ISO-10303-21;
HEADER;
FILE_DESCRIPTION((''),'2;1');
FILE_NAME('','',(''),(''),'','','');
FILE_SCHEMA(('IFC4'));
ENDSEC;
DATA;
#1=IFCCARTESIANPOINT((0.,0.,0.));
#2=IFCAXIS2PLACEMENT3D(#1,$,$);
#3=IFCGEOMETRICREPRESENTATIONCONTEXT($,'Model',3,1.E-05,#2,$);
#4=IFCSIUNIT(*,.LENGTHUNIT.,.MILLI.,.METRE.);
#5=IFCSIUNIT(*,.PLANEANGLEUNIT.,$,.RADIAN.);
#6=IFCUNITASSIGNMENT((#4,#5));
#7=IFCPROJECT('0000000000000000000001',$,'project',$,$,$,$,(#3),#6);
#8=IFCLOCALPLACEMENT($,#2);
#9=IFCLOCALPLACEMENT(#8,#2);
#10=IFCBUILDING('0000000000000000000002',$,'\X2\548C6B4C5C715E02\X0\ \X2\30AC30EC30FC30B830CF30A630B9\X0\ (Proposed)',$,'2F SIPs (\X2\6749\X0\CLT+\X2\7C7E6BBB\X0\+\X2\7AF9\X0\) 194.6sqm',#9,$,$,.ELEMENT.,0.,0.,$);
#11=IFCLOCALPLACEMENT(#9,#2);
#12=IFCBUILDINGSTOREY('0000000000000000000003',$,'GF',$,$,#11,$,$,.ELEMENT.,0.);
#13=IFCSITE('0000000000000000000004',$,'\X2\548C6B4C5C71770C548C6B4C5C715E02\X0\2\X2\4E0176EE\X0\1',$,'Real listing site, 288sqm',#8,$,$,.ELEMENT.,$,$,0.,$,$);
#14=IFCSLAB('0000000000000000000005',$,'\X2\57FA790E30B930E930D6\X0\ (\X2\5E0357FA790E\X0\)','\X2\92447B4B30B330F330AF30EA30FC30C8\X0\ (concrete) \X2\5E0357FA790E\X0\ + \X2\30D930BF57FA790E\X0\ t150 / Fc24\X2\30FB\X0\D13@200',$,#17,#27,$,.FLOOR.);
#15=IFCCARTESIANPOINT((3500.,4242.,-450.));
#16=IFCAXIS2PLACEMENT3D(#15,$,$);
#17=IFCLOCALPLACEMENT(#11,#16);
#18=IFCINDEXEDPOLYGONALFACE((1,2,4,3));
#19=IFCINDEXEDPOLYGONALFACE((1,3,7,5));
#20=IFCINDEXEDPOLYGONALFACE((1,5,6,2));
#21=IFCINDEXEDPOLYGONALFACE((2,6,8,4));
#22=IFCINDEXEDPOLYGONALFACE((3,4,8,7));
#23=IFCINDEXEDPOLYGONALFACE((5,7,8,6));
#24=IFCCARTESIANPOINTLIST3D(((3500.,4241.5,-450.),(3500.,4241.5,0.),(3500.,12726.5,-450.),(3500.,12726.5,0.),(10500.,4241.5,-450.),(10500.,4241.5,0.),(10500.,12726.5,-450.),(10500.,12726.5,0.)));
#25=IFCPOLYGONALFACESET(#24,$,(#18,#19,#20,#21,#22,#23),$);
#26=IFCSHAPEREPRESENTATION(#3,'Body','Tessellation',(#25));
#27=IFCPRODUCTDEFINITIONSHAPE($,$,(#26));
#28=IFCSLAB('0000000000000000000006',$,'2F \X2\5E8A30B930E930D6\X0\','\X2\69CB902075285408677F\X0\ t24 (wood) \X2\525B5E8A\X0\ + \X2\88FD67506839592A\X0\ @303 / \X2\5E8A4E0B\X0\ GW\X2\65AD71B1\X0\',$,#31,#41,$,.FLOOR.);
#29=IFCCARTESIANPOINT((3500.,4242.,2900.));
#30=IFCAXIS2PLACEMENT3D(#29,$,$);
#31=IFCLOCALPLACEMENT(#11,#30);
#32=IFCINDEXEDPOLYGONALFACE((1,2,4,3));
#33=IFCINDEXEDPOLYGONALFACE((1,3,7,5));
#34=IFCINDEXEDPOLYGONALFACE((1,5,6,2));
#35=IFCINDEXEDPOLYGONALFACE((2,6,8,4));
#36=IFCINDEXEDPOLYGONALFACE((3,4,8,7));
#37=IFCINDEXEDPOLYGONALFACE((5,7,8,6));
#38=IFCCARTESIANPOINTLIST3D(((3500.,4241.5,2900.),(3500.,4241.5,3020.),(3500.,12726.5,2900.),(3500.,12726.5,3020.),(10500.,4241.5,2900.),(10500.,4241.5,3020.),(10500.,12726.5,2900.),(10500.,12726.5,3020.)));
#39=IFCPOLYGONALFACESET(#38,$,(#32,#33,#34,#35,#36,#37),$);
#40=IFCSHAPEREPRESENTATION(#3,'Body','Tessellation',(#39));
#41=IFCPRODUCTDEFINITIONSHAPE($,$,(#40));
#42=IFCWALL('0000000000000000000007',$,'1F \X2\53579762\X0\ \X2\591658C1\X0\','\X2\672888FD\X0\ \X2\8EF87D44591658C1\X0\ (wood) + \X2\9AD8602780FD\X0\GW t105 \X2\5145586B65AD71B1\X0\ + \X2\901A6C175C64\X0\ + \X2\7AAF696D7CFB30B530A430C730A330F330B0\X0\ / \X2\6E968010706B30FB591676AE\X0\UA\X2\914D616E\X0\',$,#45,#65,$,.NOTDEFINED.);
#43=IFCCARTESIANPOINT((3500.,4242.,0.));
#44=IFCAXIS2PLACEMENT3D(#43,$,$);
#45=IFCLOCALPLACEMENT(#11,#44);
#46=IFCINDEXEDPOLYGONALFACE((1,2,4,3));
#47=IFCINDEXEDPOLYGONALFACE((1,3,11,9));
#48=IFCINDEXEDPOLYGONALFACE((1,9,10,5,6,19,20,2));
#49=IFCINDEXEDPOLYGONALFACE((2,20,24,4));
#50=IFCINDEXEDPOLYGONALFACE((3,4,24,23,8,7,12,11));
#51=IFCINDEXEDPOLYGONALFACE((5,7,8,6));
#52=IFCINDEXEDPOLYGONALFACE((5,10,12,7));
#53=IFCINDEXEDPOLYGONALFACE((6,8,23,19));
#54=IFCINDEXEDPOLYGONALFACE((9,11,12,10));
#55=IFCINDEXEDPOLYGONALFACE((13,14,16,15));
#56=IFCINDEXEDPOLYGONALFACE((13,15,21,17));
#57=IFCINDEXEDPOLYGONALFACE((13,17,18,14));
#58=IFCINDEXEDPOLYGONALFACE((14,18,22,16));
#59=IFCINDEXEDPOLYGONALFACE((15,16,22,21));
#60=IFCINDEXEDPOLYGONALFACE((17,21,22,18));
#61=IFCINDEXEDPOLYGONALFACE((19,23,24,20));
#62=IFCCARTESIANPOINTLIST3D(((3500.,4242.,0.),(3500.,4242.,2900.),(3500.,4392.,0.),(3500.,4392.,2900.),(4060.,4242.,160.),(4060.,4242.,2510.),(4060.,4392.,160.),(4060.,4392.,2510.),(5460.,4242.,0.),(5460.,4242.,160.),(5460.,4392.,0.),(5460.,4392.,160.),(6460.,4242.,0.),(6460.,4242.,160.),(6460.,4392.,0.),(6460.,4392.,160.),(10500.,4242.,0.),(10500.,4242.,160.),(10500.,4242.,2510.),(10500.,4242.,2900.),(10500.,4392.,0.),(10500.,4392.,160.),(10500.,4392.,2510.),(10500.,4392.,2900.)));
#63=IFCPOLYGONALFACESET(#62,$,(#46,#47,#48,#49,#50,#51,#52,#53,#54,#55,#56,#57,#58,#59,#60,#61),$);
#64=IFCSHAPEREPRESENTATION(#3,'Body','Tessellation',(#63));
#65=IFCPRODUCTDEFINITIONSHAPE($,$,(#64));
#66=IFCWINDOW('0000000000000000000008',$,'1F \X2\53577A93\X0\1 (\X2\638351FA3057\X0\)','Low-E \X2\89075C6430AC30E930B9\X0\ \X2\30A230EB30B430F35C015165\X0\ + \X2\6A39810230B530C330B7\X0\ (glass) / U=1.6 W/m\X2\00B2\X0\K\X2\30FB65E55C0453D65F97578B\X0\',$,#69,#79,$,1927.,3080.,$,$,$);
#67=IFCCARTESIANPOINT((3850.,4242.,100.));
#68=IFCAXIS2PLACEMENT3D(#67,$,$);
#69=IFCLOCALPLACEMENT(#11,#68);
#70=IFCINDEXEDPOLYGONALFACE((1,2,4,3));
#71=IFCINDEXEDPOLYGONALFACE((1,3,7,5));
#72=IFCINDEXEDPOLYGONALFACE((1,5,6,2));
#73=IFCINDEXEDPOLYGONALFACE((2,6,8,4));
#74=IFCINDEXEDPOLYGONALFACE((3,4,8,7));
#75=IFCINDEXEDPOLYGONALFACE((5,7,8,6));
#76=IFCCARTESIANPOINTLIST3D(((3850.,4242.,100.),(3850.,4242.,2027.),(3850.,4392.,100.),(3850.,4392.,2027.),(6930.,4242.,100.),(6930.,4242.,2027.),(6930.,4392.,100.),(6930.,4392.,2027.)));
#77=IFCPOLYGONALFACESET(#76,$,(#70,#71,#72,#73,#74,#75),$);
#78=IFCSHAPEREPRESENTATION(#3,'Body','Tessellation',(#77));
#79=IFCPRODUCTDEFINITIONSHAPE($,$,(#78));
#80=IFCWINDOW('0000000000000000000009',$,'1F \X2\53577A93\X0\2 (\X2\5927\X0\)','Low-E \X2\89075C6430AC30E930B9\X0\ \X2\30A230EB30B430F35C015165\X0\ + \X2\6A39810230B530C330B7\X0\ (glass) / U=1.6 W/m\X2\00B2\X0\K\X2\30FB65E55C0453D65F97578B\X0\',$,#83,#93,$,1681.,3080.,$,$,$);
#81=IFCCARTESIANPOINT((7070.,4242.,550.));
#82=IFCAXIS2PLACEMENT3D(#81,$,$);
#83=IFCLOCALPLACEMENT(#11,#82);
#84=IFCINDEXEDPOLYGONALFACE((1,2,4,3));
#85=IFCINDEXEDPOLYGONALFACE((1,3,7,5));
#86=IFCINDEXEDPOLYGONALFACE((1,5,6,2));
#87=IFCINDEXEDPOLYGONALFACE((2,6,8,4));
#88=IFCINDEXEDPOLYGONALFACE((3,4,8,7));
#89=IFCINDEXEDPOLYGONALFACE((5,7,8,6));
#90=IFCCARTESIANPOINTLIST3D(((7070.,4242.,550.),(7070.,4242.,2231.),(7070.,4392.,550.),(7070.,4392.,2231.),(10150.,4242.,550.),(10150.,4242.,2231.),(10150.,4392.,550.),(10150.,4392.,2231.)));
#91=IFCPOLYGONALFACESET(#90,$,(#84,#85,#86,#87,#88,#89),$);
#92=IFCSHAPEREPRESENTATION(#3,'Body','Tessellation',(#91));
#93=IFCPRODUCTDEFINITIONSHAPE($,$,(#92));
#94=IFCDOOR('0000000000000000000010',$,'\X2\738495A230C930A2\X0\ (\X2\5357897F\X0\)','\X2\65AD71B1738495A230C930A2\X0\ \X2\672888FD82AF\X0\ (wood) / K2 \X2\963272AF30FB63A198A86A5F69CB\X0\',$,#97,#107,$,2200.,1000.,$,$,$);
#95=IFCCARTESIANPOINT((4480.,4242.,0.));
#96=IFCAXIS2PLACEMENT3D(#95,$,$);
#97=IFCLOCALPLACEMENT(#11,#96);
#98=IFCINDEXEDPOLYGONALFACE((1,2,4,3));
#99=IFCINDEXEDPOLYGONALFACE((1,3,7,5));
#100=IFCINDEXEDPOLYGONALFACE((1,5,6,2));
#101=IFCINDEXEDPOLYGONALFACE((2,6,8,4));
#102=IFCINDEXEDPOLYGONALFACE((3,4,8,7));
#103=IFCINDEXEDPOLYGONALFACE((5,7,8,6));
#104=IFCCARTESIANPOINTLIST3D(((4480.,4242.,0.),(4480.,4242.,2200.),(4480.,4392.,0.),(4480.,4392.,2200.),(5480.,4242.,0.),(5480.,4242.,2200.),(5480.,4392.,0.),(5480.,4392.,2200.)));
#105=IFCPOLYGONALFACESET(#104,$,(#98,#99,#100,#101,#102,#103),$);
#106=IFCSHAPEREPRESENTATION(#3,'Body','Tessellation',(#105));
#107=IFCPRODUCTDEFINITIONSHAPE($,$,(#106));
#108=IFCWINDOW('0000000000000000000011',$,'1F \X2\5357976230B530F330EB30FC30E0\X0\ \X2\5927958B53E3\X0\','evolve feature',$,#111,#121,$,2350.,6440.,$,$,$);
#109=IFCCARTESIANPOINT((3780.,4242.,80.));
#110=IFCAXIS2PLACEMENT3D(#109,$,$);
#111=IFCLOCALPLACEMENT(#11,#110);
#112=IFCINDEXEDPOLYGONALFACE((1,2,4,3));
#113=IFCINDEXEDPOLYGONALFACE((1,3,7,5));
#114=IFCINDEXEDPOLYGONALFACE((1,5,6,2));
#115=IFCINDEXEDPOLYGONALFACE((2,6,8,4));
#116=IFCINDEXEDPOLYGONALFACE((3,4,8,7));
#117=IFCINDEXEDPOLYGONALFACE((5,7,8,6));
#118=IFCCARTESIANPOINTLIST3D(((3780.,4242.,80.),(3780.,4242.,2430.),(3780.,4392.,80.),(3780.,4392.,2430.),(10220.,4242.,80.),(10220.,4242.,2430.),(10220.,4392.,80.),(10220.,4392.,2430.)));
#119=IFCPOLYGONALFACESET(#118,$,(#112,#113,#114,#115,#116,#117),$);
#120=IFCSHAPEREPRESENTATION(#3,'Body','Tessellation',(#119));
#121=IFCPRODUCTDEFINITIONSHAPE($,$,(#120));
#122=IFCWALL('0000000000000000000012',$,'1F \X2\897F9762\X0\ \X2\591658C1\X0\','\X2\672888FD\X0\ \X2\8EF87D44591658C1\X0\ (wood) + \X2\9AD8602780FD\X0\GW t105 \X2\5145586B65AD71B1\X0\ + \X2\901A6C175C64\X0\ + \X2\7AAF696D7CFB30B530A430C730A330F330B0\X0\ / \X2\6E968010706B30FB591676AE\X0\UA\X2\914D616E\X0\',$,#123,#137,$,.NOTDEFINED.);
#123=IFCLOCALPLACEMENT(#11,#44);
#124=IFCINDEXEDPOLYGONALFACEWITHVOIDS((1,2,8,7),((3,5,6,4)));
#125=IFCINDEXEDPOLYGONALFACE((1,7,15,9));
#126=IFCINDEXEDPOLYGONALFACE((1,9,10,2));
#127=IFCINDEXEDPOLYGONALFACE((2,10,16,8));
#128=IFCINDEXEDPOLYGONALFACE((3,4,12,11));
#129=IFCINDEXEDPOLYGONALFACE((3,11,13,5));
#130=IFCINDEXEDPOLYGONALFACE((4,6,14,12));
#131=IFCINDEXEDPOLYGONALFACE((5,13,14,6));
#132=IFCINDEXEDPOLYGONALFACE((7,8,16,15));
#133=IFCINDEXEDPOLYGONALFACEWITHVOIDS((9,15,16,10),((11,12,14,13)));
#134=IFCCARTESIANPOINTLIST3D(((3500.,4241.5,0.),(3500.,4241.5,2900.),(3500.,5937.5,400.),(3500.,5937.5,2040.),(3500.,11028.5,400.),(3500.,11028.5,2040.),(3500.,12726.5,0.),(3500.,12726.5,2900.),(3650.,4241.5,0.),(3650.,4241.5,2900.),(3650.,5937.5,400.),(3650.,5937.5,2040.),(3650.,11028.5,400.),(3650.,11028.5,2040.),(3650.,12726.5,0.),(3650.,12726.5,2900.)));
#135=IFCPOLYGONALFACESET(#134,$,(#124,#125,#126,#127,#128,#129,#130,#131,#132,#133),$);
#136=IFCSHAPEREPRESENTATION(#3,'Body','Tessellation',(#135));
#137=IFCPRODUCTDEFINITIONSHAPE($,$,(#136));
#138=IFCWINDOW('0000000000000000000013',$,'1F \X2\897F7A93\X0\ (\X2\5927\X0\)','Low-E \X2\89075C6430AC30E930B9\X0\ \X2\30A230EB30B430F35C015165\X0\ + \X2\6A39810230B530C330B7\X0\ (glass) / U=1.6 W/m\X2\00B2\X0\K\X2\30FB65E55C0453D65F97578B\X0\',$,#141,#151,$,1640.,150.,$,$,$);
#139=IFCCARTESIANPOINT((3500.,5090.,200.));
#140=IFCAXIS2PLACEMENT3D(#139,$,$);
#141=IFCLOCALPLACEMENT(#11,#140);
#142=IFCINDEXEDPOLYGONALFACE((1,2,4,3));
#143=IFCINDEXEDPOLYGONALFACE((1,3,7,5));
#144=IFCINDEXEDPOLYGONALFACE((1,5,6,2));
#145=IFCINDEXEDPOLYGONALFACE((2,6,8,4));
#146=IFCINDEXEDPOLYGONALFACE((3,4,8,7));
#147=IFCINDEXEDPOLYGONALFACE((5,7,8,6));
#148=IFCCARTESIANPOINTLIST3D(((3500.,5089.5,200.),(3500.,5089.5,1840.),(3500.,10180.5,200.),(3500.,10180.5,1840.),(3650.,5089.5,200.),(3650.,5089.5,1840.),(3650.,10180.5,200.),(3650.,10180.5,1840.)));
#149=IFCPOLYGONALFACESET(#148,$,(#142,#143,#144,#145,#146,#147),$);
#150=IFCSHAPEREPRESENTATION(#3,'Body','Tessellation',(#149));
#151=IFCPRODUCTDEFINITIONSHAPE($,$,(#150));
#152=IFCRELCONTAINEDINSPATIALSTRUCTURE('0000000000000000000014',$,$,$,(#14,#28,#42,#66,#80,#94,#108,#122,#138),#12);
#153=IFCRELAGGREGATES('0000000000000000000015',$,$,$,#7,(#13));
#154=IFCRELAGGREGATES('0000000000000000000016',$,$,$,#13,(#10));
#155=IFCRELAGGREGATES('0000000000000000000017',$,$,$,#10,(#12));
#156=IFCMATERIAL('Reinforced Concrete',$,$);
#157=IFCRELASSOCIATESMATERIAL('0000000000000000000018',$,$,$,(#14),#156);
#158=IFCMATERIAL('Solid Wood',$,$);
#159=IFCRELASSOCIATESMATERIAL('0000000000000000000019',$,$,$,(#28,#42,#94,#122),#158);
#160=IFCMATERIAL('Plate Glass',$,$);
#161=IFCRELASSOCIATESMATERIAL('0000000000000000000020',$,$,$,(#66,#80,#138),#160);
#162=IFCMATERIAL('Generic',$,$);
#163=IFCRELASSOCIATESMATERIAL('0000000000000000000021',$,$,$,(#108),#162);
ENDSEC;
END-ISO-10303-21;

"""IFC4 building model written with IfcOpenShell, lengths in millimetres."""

from ifc_helpers import new_model, si_unit, frame, frame_2d, origin, place, context, project, spatial, rectangle, extrude, material, element, fill, save


model = new_model("IFC4")

# Units and contexts
model_context = context("Model", 3, precision=1e-05, world=origin())
ifc_project = project(units=[si_unit("LENGTHUNIT", "METRE", prefix="MILLI"), si_unit("PLANEANGLEUNIT", "RADIAN")], contexts=[model_context])

# Site, building, storey
site_placement = place(None, origin())
site = spatial("IfcSite", under=ifc_project, at=site_placement, Name="和歌山県和歌山市2丁目1", ObjectType="Real listing site, 288sqm", CompositionType="ELEMENT", RefElevation=0.0)
building_placement = place(site_placement, origin())
building = spatial("IfcBuilding", under=site, at=building_placement, Name="和歌山市 ガレージハウス (Proposed)", ObjectType="2F SIPs (杉CLT+籾殻+竹) 194.6sqm", CompositionType="ELEMENT", ElevationOfRefHeight=0.0, ElevationOfTerrain=0.0)
storey_placement = place(building_placement, origin())
storey = spatial("IfcBuildingStorey", under=building, at=storey_placement, Name="GF", CompositionType="ELEMENT", Elevation=0.0)

# Slabs
ifc_material_1 = material(Name="Reinforced Concrete")
slab_1_placement = place(storey_placement, frame((3500.0, 4242.0, -450.0)))
element("IfcSlab", 1, at=slab_1_placement, inside=storey, material=ifc_material_1, Name="基礎スラブ (布基礎)", Description="鉄筋コンクリート (concrete) 布基礎 + ベタ基礎 t150 / Fc24・D13@200", PredefinedType="FLOOR", context=model_context, shape_type="SweptSolid", body=[
    extrude(rectangle(XDim=7000.0, YDim=8485.0, at=frame_2d((3500.0, 4242.0))), frame((3500.0, 4242.0, -450.0)), (0.0, 0.0, 1.0), 450.0),
])
ifc_material_2 = material(Name="Solid Wood")
slab_2_placement = place(storey_placement, frame((3500.0, 4242.0, 2900.0)))
element("IfcSlab", 2, at=slab_2_placement, inside=storey, material=ifc_material_2, Name="2F 床スラブ", Description="構造用合板 t24 (wood) 剛床 + 製材根太 @303 / 床下 GW断熱", PredefinedType="FLOOR", context=model_context, shape_type="SweptSolid", body=[
    extrude(rectangle(XDim=7000.0, YDim=8485.0, at=frame_2d((3500.0, 4242.0))), frame((3500.0, 4242.0, 2900.0)), (0.0, 0.0, 1.0), 120.0),
])

# Wall, openings, windows, door
wall_1_placement = place(storey_placement, frame((3500.0, 4242.0, 0.0)))
wall_1 = element("IfcWall", 3, at=wall_1_placement, inside=storey, material=ifc_material_2, Name="1F 南面 外壁", Description="木製 軸組外壁 (wood) + 高性能GW t105 充填断熱 + 通気層 + 窯業系サイディング / 準耐火・外皮UA配慮", PredefinedType="NOTDEFINED", context=model_context, shape_type="SweptSolid", body=[
    extrude(rectangle(XDim=7000.0, YDim=150.0, at=frame_2d((3500.0, 75.0))), frame((3500.0, 4242.0, 0.0)), (0.0, 0.0, 1.0), 2900.0),
])
opening_1_placement = place(storey_placement, frame((3850.0, 4242.0, 100.0)))
opening_1 = element("IfcOpeningElement", 4, at=opening_1_placement, cuts=wall_1, PredefinedType="NOTDEFINED", context=model_context, shape_type="SweptSolid", body=[
    extrude(rectangle(XDim=3080.0, YDim=150.0, at=frame_2d((1540.0, 75.0))), frame((3850.0, 4242.0, 100.0)), (0.0, 0.0, 1.0), 1927.0),
])
opening_2_placement = place(storey_placement, frame((7070.0, 4242.0, 550.0)))
opening_2 = element("IfcOpeningElement", 5, at=opening_2_placement, cuts=wall_1, PredefinedType="NOTDEFINED", context=model_context, shape_type="SweptSolid", body=[
    extrude(rectangle(XDim=3080.0, YDim=150.0, at=frame_2d((1540.0, 75.0))), frame((7070.0, 4242.0, 550.0)), (0.0, 0.0, 1.0), 1681.0),
])
opening_3_placement = place(storey_placement, frame((4480.0, 4242.0, 0.0)))
opening_3 = element("IfcOpeningElement", 6, at=opening_3_placement, cuts=wall_1, PredefinedType="NOTDEFINED", context=model_context, shape_type="SweptSolid", body=[
    extrude(rectangle(XDim=1000.0, YDim=150.0, at=frame_2d((500.0, 75.0))), frame((4480.0, 4242.0, 0.0)), (0.0, 0.0, 1.0), 2200.0),
])
opening_4_placement = place(storey_placement, frame((3780.0, 4242.0, 80.0)))
opening_4 = element("IfcOpeningElement", 7, at=opening_4_placement, cuts=wall_1, PredefinedType="NOTDEFINED", context=model_context, shape_type="SweptSolid", body=[
    extrude(rectangle(XDim=6440.0, YDim=150.0, at=frame_2d((3220.0, 75.0))), frame((3780.0, 4242.0, 80.0)), (0.0, 0.0, 1.0), 2350.0),
])
ifc_material_3 = material(Name="Plate Glass")
window_1_placement = place(storey_placement, frame((3850.0, 4242.0, 100.0)))
window_1 = element("IfcWindow", 8, at=window_1_placement, inside=storey, material=ifc_material_3, Name="1F 南窓1 (掃出し)", Description="Low-E 複層ガラス アルゴン封入 + 樹脂サッシ (glass) / U=1.6 W/m²K・日射取得型", OverallHeight=1927.0, OverallWidth=3080.0, context=model_context, shape_type="SweptSolid", body=[
    extrude(rectangle(XDim=3080.0, YDim=150.0, at=frame_2d((1540.0, 75.0))), frame((3850.0, 4242.0, 100.0)), (0.0, 0.0, 1.0), 1927.0),
])
fill(opening_1, window_1)
window_2_placement = place(storey_placement, frame((7070.0, 4242.0, 550.0)))
window_2 = element("IfcWindow", 9, at=window_2_placement, inside=storey, material=ifc_material_3, Name="1F 南窓2 (大)", Description="Low-E 複層ガラス アルゴン封入 + 樹脂サッシ (glass) / U=1.6 W/m²K・日射取得型", OverallHeight=1681.0, OverallWidth=3080.0, context=model_context, shape_type="SweptSolid", body=[
    extrude(rectangle(XDim=3080.0, YDim=150.0, at=frame_2d((1540.0, 75.0))), frame((7070.0, 4242.0, 550.0)), (0.0, 0.0, 1.0), 1681.0),
])
fill(opening_2, window_2)
door_placement = place(storey_placement, frame((4480.0, 4242.0, 0.0)))
door = element("IfcDoor", 10, at=door_placement, inside=storey, material=ifc_material_2, Name="玄関ドア (南西)", Description="断熱玄関ドア 木製芯 (wood) / K2 防犯・採風機構", OverallHeight=2200.0, OverallWidth=1000.0, context=model_context, shape_type="SweptSolid", body=[
    extrude(rectangle(XDim=1000.0, YDim=150.0, at=frame_2d((500.0, 75.0))), frame((4480.0, 4242.0, 0.0)), (0.0, 0.0, 1.0), 2200.0),
])
fill(opening_3, door)
ifc_material_4 = material(Name="Generic")
window_3_placement = place(storey_placement, frame((3780.0, 4242.0, 80.0)))
window_3 = element("IfcWindow", 11, at=window_3_placement, inside=storey, material=ifc_material_4, Name="1F 南面サンルーム 大開口", Description="evolve feature", OverallHeight=2350.0, OverallWidth=6440.0, context=model_context, shape_type="SweptSolid", body=[
    extrude(rectangle(XDim=6440.0, YDim=150.0, at=frame_2d((3220.0, 75.0))), frame((3780.0, 4242.0, 80.0)), (0.0, 0.0, 1.0), 2350.0),
])
fill(opening_4, window_3)

# Wall, opening, window
wall_2_placement = place(storey_placement, frame((3500.0, 4242.0, 0.0)))
wall_2 = element("IfcWall", 12, at=wall_2_placement, inside=storey, material=ifc_material_2, Name="1F 西面 外壁", Description="木製 軸組外壁 (wood) + 高性能GW t105 充填断熱 + 通気層 + 窯業系サイディング / 準耐火・外皮UA配慮", PredefinedType="NOTDEFINED", context=model_context, shape_type="SweptSolid", body=[
    extrude(rectangle(XDim=150.0, YDim=8485.0, at=frame_2d((75.0, 4242.0))), frame((3500.0, 4242.0, 0.0)), (0.0, 0.0, 1.0), 2900.0),
])
opening_5_placement = place(storey_placement, frame((3500.0, 5090.0, 200.0)))
opening_5 = element("IfcOpeningElement", 13, at=opening_5_placement, cuts=wall_2, PredefinedType="NOTDEFINED", context=model_context, shape_type="SweptSolid", body=[
    extrude(rectangle(XDim=150.0, YDim=5091.0, at=frame_2d((75.0, 2545.0))), frame((3500.0, 5090.0, 200.0)), (0.0, 0.0, 1.0), 1640.0),
])
window_4_placement = place(storey_placement, frame((3500.0, 5090.0, 200.0)))
window_4 = element("IfcWindow", 14, at=window_4_placement, inside=storey, material=ifc_material_3, Name="1F 西窓 (大)", Description="Low-E 複層ガラス アルゴン封入 + 樹脂サッシ (glass) / U=1.6 W/m²K・日射取得型", OverallHeight=1640.0, OverallWidth=150.0, context=model_context, shape_type="SweptSolid", body=[
    extrude(rectangle(XDim=150.0, YDim=5091.0, at=frame_2d((75.0, 2545.0))), frame((3500.0, 5090.0, 200.0)), (0.0, 0.0, 1.0), 1640.0),
])
fill(opening_5, window_4)

save(model, "model.ifc")
